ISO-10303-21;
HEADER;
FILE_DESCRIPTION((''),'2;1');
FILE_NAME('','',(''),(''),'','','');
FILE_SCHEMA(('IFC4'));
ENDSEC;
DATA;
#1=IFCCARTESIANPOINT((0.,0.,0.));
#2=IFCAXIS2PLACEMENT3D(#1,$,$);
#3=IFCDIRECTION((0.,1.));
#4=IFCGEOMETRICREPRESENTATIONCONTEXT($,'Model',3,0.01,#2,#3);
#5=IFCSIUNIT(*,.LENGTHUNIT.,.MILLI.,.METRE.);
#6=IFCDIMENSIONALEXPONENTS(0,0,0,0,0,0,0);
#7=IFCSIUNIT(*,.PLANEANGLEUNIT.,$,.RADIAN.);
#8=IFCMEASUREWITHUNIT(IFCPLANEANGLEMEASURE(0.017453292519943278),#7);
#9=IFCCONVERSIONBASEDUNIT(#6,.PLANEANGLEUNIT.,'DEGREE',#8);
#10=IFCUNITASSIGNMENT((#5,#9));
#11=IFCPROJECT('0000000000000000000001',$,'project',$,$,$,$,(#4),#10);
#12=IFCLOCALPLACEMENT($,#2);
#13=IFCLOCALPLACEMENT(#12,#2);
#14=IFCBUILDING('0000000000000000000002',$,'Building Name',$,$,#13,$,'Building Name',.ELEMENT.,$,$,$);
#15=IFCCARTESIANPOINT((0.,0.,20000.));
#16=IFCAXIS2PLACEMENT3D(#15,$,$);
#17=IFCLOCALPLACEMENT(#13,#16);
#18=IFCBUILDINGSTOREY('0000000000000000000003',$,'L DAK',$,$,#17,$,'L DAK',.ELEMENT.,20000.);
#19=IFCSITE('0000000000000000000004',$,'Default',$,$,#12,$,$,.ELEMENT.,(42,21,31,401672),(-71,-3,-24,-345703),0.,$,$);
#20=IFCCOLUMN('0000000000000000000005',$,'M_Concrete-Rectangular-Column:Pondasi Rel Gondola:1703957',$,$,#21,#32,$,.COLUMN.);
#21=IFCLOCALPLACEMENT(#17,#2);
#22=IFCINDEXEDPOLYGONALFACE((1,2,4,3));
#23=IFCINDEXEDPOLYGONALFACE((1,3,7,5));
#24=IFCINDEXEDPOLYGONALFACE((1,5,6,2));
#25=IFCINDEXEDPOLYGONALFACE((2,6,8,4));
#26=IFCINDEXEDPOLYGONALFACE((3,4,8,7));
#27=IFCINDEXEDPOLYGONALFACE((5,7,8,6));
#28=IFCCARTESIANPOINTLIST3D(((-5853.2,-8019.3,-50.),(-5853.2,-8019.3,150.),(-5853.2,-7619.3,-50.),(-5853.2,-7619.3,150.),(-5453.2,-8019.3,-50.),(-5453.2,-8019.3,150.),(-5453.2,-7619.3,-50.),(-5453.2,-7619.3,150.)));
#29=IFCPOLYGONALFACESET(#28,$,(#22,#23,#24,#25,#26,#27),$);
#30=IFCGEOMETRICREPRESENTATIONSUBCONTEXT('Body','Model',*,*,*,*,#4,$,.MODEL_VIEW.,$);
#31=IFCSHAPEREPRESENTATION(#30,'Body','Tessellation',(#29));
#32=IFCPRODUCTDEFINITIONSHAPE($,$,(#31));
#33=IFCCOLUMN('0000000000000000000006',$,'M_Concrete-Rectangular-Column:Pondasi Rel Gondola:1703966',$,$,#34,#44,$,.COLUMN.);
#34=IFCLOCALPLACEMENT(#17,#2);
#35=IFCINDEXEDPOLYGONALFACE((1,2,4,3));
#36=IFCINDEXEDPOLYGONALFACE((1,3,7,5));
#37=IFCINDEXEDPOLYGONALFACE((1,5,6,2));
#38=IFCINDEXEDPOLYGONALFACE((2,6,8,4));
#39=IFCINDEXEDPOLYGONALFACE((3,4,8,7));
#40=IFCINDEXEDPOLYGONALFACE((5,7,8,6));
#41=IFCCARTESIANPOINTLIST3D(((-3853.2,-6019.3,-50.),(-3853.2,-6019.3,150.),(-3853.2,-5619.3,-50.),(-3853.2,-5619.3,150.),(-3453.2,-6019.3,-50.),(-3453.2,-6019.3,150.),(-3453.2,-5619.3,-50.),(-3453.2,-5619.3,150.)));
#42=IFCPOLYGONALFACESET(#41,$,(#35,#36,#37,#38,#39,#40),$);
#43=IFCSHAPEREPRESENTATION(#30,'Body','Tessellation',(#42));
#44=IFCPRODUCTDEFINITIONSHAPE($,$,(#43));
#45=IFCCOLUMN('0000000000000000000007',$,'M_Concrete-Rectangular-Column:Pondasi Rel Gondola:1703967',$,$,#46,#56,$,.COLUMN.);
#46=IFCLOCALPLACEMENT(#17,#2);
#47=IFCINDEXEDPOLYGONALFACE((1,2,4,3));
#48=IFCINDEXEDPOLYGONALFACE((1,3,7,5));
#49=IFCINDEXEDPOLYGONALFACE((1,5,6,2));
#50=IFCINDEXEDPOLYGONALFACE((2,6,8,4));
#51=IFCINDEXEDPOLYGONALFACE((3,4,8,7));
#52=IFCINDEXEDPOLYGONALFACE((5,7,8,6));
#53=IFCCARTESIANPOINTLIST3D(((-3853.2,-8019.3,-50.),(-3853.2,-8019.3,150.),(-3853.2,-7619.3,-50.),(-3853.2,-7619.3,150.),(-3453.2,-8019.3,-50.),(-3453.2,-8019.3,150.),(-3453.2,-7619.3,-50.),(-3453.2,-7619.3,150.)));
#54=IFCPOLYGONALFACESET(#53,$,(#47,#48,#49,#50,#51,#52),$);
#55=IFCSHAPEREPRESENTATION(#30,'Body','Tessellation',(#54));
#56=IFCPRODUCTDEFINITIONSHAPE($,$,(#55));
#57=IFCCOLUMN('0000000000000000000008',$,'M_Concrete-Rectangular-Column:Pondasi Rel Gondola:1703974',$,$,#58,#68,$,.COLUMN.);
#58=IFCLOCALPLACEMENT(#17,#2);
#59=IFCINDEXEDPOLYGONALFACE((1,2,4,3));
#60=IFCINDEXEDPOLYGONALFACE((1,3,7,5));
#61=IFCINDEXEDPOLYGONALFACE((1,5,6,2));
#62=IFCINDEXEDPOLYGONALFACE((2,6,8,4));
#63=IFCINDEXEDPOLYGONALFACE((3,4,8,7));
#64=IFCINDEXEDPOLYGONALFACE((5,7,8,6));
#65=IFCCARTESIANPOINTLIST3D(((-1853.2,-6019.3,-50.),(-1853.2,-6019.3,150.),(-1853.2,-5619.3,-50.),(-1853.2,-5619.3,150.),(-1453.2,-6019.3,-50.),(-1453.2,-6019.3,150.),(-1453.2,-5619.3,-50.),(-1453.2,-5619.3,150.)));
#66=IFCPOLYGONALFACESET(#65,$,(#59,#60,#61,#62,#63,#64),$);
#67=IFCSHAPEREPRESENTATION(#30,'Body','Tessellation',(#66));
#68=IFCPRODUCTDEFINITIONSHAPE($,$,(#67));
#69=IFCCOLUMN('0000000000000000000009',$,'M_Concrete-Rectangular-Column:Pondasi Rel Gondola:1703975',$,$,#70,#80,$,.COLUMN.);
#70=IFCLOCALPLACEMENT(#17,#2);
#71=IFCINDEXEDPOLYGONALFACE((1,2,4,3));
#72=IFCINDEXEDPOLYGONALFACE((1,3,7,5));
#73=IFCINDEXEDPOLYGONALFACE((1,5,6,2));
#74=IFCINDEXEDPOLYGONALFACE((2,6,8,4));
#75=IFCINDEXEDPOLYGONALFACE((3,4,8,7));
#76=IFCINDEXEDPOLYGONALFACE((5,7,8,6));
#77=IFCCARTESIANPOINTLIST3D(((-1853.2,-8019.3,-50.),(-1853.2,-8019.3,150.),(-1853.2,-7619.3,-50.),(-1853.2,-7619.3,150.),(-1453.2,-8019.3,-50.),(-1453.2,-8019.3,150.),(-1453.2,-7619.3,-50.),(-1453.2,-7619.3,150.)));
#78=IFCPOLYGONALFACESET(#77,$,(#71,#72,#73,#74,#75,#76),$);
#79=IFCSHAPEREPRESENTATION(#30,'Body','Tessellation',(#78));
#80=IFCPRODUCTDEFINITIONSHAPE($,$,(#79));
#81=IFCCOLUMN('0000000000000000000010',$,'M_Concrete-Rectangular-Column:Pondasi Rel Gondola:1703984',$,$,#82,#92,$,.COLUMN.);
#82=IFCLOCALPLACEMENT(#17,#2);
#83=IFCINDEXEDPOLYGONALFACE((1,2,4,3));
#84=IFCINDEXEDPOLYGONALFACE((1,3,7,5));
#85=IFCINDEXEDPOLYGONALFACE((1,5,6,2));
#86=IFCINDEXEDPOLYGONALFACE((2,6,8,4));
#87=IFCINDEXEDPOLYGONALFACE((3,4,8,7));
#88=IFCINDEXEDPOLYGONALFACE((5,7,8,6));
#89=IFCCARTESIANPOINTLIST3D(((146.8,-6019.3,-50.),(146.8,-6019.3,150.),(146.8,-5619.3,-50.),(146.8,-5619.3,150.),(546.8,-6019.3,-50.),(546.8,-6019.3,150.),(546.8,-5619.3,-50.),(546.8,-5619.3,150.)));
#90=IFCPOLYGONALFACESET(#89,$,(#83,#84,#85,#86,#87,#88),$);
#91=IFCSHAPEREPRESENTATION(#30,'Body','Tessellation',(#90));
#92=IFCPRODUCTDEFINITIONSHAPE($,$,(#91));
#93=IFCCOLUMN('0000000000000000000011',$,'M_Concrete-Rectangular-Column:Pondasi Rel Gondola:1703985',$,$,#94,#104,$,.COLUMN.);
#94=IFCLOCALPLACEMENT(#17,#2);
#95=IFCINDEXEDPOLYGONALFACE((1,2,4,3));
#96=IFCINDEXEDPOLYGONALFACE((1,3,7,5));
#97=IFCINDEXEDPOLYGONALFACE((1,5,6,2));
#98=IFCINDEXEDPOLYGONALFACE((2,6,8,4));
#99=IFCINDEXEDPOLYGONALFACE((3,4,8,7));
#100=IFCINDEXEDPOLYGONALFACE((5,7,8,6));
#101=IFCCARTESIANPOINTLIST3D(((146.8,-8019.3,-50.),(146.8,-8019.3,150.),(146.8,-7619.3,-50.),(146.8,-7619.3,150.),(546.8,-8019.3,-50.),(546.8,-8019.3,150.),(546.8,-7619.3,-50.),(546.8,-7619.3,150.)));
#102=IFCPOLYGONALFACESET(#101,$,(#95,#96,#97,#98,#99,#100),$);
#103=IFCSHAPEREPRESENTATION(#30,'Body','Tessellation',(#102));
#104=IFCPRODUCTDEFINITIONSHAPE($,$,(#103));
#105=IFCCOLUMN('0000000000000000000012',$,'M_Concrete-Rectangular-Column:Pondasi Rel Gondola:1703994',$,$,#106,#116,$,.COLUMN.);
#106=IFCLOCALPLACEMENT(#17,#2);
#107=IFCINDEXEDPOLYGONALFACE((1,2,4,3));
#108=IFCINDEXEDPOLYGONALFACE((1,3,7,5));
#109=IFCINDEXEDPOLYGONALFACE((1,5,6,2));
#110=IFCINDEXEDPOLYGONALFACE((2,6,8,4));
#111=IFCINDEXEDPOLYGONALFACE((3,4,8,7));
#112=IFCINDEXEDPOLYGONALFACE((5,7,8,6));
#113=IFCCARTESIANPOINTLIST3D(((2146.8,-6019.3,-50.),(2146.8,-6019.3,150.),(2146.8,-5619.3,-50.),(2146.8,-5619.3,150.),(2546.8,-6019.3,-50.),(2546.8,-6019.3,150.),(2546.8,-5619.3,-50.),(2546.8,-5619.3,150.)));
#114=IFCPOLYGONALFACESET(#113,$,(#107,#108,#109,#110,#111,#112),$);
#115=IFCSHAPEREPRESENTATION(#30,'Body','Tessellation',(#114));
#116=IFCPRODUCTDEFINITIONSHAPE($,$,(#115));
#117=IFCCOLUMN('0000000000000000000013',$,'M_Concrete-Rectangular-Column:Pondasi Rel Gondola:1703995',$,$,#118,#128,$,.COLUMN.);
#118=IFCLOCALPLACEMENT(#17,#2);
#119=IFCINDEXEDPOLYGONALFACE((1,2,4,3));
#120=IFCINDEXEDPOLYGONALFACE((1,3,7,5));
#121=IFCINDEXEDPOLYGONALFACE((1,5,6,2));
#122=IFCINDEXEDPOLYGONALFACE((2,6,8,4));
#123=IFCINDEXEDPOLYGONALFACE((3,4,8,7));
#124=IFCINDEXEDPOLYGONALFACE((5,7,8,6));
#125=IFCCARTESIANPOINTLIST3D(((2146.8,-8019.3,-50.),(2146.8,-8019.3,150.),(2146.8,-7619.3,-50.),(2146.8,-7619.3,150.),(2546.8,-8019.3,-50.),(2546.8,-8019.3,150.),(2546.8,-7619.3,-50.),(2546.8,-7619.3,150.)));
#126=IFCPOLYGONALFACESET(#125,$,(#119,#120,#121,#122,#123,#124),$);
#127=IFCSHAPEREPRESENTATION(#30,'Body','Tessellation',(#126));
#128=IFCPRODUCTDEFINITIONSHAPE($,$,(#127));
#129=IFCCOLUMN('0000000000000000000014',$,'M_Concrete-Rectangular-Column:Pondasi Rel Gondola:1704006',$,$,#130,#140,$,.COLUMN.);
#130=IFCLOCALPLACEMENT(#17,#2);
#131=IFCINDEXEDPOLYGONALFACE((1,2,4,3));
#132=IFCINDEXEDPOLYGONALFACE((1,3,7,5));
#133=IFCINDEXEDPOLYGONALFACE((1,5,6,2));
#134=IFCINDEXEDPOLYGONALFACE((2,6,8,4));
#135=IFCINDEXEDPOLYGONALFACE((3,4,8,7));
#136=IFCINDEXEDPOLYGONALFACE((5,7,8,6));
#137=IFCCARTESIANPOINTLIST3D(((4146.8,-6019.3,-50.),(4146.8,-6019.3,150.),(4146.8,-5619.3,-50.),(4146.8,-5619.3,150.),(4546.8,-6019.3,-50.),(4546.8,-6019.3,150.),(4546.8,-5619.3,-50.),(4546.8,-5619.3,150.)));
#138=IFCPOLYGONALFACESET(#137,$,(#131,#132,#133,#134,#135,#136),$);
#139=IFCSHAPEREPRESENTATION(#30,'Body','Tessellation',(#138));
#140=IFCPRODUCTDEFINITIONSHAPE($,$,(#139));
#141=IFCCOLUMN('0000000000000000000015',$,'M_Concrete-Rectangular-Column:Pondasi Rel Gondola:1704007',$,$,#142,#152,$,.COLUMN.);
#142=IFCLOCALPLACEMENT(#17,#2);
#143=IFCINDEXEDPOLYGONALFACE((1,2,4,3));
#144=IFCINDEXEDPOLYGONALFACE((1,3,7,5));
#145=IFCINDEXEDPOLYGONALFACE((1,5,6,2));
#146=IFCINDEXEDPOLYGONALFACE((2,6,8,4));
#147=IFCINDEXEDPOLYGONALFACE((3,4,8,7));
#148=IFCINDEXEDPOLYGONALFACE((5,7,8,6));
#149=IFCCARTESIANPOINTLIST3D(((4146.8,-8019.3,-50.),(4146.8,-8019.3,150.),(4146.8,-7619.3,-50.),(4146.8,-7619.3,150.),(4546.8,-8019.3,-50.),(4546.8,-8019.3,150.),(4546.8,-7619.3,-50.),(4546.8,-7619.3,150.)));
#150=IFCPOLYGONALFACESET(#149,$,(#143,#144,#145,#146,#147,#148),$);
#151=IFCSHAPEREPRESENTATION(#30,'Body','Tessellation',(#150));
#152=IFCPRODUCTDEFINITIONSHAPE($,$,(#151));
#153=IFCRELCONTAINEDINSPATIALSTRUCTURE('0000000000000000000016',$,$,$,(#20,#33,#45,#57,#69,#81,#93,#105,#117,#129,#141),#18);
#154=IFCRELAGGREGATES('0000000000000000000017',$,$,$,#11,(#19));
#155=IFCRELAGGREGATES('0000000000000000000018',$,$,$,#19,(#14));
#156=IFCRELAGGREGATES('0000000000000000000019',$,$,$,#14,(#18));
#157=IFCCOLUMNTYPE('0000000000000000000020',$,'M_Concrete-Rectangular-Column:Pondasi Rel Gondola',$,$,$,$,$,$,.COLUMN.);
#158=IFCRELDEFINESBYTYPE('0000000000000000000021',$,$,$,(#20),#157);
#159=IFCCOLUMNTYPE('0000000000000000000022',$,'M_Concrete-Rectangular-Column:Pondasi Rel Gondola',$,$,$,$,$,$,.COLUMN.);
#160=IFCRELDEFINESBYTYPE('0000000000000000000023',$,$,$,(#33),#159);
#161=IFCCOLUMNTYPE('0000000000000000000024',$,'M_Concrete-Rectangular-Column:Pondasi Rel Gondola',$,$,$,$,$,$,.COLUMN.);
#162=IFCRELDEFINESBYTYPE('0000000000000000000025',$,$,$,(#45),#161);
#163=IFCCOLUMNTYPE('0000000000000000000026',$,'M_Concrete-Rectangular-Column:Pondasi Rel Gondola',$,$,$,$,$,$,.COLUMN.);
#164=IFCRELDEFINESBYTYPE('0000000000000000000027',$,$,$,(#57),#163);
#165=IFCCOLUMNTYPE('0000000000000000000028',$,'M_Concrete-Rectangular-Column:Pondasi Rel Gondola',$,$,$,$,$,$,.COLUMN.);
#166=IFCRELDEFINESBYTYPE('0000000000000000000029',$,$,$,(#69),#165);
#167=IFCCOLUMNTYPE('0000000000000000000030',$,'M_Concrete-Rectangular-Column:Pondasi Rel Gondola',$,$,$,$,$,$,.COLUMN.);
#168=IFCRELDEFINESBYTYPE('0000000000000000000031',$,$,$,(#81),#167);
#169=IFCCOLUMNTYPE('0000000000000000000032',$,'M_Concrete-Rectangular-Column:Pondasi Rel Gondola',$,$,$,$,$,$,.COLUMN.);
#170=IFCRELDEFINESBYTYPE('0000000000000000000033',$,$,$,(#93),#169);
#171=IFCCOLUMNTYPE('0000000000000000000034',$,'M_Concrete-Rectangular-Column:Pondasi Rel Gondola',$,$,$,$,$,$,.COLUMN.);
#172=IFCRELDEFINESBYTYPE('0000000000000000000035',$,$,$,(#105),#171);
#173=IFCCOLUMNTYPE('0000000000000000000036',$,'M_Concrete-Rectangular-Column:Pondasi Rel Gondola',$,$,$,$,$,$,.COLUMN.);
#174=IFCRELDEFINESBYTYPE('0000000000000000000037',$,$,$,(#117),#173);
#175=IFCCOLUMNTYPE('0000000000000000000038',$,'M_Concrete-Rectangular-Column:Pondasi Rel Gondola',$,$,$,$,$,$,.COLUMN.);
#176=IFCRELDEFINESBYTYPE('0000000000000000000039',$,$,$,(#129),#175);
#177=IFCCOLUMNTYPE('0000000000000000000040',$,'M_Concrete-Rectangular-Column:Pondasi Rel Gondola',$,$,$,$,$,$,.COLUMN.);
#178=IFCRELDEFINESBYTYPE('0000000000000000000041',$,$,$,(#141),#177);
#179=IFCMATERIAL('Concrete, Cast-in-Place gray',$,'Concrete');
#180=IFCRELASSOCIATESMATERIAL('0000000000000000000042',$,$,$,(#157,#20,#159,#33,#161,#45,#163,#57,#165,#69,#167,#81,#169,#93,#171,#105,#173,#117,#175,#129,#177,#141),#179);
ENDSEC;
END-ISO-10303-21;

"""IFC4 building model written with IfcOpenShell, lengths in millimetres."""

from ifc_helpers import new_model, entity, si_unit, converted_unit, direction, frame, origin, place, context, subcontext, project, spatial, indexed_curve, outline, extrude, source, transform, mapped, material, type_object, type_shapes, element, save


model = new_model("IFC4")

# Units and contexts
model_context = context("Model", 3, precision=0.01, world=origin(), true_north=direction((0.0, 1.0)))
body_context = subcontext(model_context, "Body", "Model", "MODEL_VIEW")
ifc_project = project(units=[si_unit("LENGTHUNIT", "METRE", prefix="MILLI"), converted_unit("PLANEANGLEUNIT", "DEGREE", entity("IfcPlaneAngleMeasure", 0.017453292519943278), si_unit("PLANEANGLEUNIT", "RADIAN"), dimensions=[0, 0, 0, 0, 0, 0, 0])], contexts=[model_context])

# Site, building, storey
site_placement = place(None, origin())
site = spatial("IfcSite", under=ifc_project, at=site_placement, Name="Default", CompositionType="ELEMENT", RefLatitude=(42, 21, 31, 401672), RefLongitude=(-71, -3, -24, -345703), RefElevation=0.0)
building_placement = place(site_placement, origin())
building = spatial("IfcBuilding", under=site, at=building_placement, Name="Building Name", LongName="Building Name", CompositionType="ELEMENT")
storey_placement = place(building_placement, frame((0.0, 0.0, 20000.0)))
storey = spatial("IfcBuildingStorey", under=building, at=storey_placement, Name="L DAK", LongName="L DAK", CompositionType="ELEMENT", Elevation=20000.0)

# Columns
ifc_material = material(Name="Concrete, Cast-in-Place gray", Category="Concrete")
column_type_1 = type_object("IfcColumnType", Name="M_Concrete-Rectangular-Column:Pondasi Rel Gondola", PredefinedType="COLUMN", material=ifc_material)
shared_shape_1 = source(origin(), body_context, "Body", "SweptSolid", [
    extrude(outline(indexed_curve([(-200.0, -200.0), (200.0, -200.0), (200.0, 200.0), (-200.0, 200.0), (-200.0, -200.0)], self_intersect=False)), frame((-5653.2, -7819.3, 19950.0), z_axis=(0.0, 0.0, 1.0), x_axis=(-1.0, 0.0, 0.0)), (0.0, 0.0, 1.0), 200.0),
])
type_shapes(column_type_1, [shared_shape_1])
column_1_placement = place(storey_placement, frame((0.0, 0.0, -20000.0)))
element("IfcColumn", 1, at=column_1_placement, inside=storey, type_object=column_type_1, material=ifc_material, Name="M_Concrete-Rectangular-Column:Pondasi Rel Gondola:1703957", PredefinedType="COLUMN", context=body_context, shape_type="MappedRepresentation", body=[
    mapped(shared_shape_1, transform((0.0, 0.0, 0.0), scale=1.0)),
])
column_type_2 = type_object("IfcColumnType", Name="M_Concrete-Rectangular-Column:Pondasi Rel Gondola", PredefinedType="COLUMN", material=ifc_material)
shared_shape_2 = source(origin(), body_context, "Body", "SweptSolid", [
    extrude(outline(indexed_curve([(-200.0, -200.0), (200.0, -200.0), (200.0, 200.0), (-200.0, 200.0), (-200.0, -200.0)], self_intersect=False)), frame((-3653.2, -5819.3, 19950.0), z_axis=(0.0, 0.0, 1.0), x_axis=(-1.0, 0.0, 0.0)), (0.0, 0.0, 1.0), 200.0),
])
type_shapes(column_type_2, [shared_shape_2])
column_2_placement = place(storey_placement, frame((0.0, 0.0, -20000.0)))
element("IfcColumn", 2, at=column_2_placement, inside=storey, type_object=column_type_2, material=ifc_material, Name="M_Concrete-Rectangular-Column:Pondasi Rel Gondola:1703966", PredefinedType="COLUMN", context=body_context, shape_type="MappedRepresentation", body=[
    mapped(shared_shape_2, transform((0.0, 0.0, 0.0), scale=1.0)),
])
column_type_3 = type_object("IfcColumnType", Name="M_Concrete-Rectangular-Column:Pondasi Rel Gondola", PredefinedType="COLUMN", material=ifc_material)
shared_shape_3 = source(origin(), body_context, "Body", "SweptSolid", [
    extrude(outline(indexed_curve([(-200.0, -200.0), (200.0, -200.0), (200.0, 200.0), (-200.0, 200.0), (-200.0, -200.0)], self_intersect=False)), frame((-3653.2, -7819.3, 19950.0), z_axis=(0.0, 0.0, 1.0), x_axis=(-1.0, 0.0, 0.0)), (0.0, 0.0, 1.0), 200.0),
])
type_shapes(column_type_3, [shared_shape_3])
column_3_placement = place(storey_placement, frame((0.0, 0.0, -20000.0)))
element("IfcColumn", 3, at=column_3_placement, inside=storey, type_object=column_type_3, material=ifc_material, Name="M_Concrete-Rectangular-Column:Pondasi Rel Gondola:1703967", PredefinedType="COLUMN", context=body_context, shape_type="MappedRepresentation", body=[
    mapped(shared_shape_3, transform((0.0, 0.0, 0.0), scale=1.0)),
])
column_type_4 = type_object("IfcColumnType", Name="M_Concrete-Rectangular-Column:Pondasi Rel Gondola", PredefinedType="COLUMN", material=ifc_material)
shared_shape_4 = source(origin(), body_context, "Body", "SweptSolid", [
    extrude(outline(indexed_curve([(-200.0, -200.0), (200.0, -200.0), (200.0, 200.0), (-200.0, 200.0), (-200.0, -200.0)], self_intersect=False)), frame((-1653.2, -5819.3, 19950.0), z_axis=(0.0, 0.0, 1.0), x_axis=(-1.0, 0.0, 0.0)), (0.0, 0.0, 1.0), 200.0),
])
type_shapes(column_type_4, [shared_shape_4])
column_4_placement = place(storey_placement, frame((0.0, 0.0, -20000.0)))
element("IfcColumn", 4, at=column_4_placement, inside=storey, type_object=column_type_4, material=ifc_material, Name="M_Concrete-Rectangular-Column:Pondasi Rel Gondola:1703974", PredefinedType="COLUMN", context=body_context, shape_type="MappedRepresentation", body=[
    mapped(shared_shape_4, transform((0.0, 0.0, 0.0), scale=1.0)),
])
column_type_5 = type_object("IfcColumnType", Name="M_Concrete-Rectangular-Column:Pondasi Rel Gondola", PredefinedType="COLUMN", material=ifc_material)
shared_shape_5 = source(origin(), body_context, "Body", "SweptSolid", [
    extrude(outline(indexed_curve([(-200.0, -200.0), (200.0, -200.0), (200.0, 200.0), (-200.0, 200.0), (-200.0, -200.0)], self_intersect=False)), frame((-1653.2, -7819.3, 19950.0), z_axis=(0.0, 0.0, 1.0), x_axis=(-1.0, 0.0, 0.0)), (0.0, 0.0, 1.0), 200.0),
])
type_shapes(column_type_5, [shared_shape_5])
column_5_placement = place(storey_placement, frame((0.0, 0.0, -20000.0)))
element("IfcColumn", 5, at=column_5_placement, inside=storey, type_object=column_type_5, material=ifc_material, Name="M_Concrete-Rectangular-Column:Pondasi Rel Gondola:1703975", PredefinedType="COLUMN", context=body_context, shape_type="MappedRepresentation", body=[
    mapped(shared_shape_5, transform((0.0, 0.0, 0.0), scale=1.0)),
])
column_type_6 = type_object("IfcColumnType", Name="M_Concrete-Rectangular-Column:Pondasi Rel Gondola", PredefinedType="COLUMN", material=ifc_material)
shared_shape_6 = source(origin(), body_context, "Body", "SweptSolid", [
    extrude(outline(indexed_curve([(-200.0, -200.0), (200.0, -200.0), (200.0, 200.0), (-200.0, 200.0), (-200.0, -200.0)], self_intersect=False)), frame((346.8, -5819.3, 19950.0), z_axis=(0.0, 0.0, 1.0), x_axis=(-1.0, 0.0, 0.0)), (0.0, 0.0, 1.0), 200.0),
])
type_shapes(column_type_6, [shared_shape_6])
column_6_placement = place(storey_placement, frame((0.0, 0.0, -20000.0)))
element("IfcColumn", 6, at=column_6_placement, inside=storey, type_object=column_type_6, material=ifc_material, Name="M_Concrete-Rectangular-Column:Pondasi Rel Gondola:1703984", PredefinedType="COLUMN", context=body_context, shape_type="MappedRepresentation", body=[
    mapped(shared_shape_6, transform((0.0, 0.0, 0.0), scale=1.0)),
])
column_type_7 = type_object("IfcColumnType", Name="M_Concrete-Rectangular-Column:Pondasi Rel Gondola", PredefinedType="COLUMN", material=ifc_material)
shared_shape_7 = source(origin(), body_context, "Body", "SweptSolid", [
    extrude(outline(indexed_curve([(-200.0, -200.0), (200.0, -200.0), (200.0, 200.0), (-200.0, 200.0), (-200.0, -200.0)], self_intersect=False)), frame((346.8, -7819.3, 19950.0), z_axis=(0.0, 0.0, 1.0), x_axis=(-1.0, 0.0, 0.0)), (0.0, 0.0, 1.0), 200.0),
])
type_shapes(column_type_7, [shared_shape_7])
column_7_placement = place(storey_placement, frame((0.0, 0.0, -20000.0)))
element("IfcColumn", 7, at=column_7_placement, inside=storey, type_object=column_type_7, material=ifc_material, Name="M_Concrete-Rectangular-Column:Pondasi Rel Gondola:1703985", PredefinedType="COLUMN", context=body_context, shape_type="MappedRepresentation", body=[
    mapped(shared_shape_7, transform((0.0, 0.0, 0.0), scale=1.0)),
])
column_type_8 = type_object("IfcColumnType", Name="M_Concrete-Rectangular-Column:Pondasi Rel Gondola", PredefinedType="COLUMN", material=ifc_material)
shared_shape_8 = source(origin(), body_context, "Body", "SweptSolid", [
    extrude(outline(indexed_curve([(-200.0, -200.0), (200.0, -200.0), (200.0, 200.0), (-200.0, 200.0), (-200.0, -200.0)], self_intersect=False)), frame((2346.8, -5819.3, 19950.0), z_axis=(0.0, 0.0, 1.0), x_axis=(-1.0, 0.0, 0.0)), (0.0, 0.0, 1.0), 200.0),
])
type_shapes(column_type_8, [shared_shape_8])
column_8_placement = place(storey_placement, frame((0.0, 0.0, -20000.0)))
element("IfcColumn", 8, at=column_8_placement, inside=storey, type_object=column_type_8, material=ifc_material, Name="M_Concrete-Rectangular-Column:Pondasi Rel Gondola:1703994", PredefinedType="COLUMN", context=body_context, shape_type="MappedRepresentation", body=[
    mapped(shared_shape_8, transform((0.0, 0.0, 0.0), scale=1.0)),
])
column_type_9 = type_object("IfcColumnType", Name="M_Concrete-Rectangular-Column:Pondasi Rel Gondola", PredefinedType="COLUMN", material=ifc_material)
shared_shape_9 = source(origin(), body_context, "Body", "SweptSolid", [
    extrude(outline(indexed_curve([(-200.0, -200.0), (200.0, -200.0), (200.0, 200.0), (-200.0, 200.0), (-200.0, -200.0)], self_intersect=False)), frame((2346.8, -7819.3, 19950.0), z_axis=(0.0, 0.0, 1.0), x_axis=(-1.0, 0.0, 0.0)), (0.0, 0.0, 1.0), 200.0),
])
type_shapes(column_type_9, [shared_shape_9])
column_9_placement = place(storey_placement, frame((0.0, 0.0, -20000.0)))
element("IfcColumn", 9, at=column_9_placement, inside=storey, type_object=column_type_9, material=ifc_material, Name="M_Concrete-Rectangular-Column:Pondasi Rel Gondola:1703995", PredefinedType="COLUMN", context=body_context, shape_type="MappedRepresentation", body=[
    mapped(shared_shape_9, transform((0.0, 0.0, 0.0), scale=1.0)),
])
column_type_10 = type_object("IfcColumnType", Name="M_Concrete-Rectangular-Column:Pondasi Rel Gondola", PredefinedType="COLUMN", material=ifc_material)
shared_shape_10 = source(origin(), body_context, "Body", "SweptSolid", [
    extrude(outline(indexed_curve([(-200.0, -200.0), (200.0, -200.0), (200.0, 200.0), (-200.0, 200.0), (-200.0, -200.0)], self_intersect=False)), frame((4346.8, -5819.3, 19950.0), z_axis=(0.0, 0.0, 1.0), x_axis=(-1.0, 0.0, 0.0)), (0.0, 0.0, 1.0), 200.0),
])
type_shapes(column_type_10, [shared_shape_10])
column_10_placement = place(storey_placement, frame((0.0, 0.0, -20000.0)))
element("IfcColumn", 10, at=column_10_placement, inside=storey, type_object=column_type_10, material=ifc_material, Name="M_Concrete-Rectangular-Column:Pondasi Rel Gondola:1704006", PredefinedType="COLUMN", context=body_context, shape_type="MappedRepresentation", body=[
    mapped(shared_shape_10, transform((0.0, 0.0, 0.0), scale=1.0)),
])
column_type_11 = type_object("IfcColumnType", Name="M_Concrete-Rectangular-Column:Pondasi Rel Gondola", PredefinedType="COLUMN", material=ifc_material)
shared_shape_11 = source(origin(), body_context, "Body", "SweptSolid", [
    extrude(outline(indexed_curve([(-200.0, -200.0), (200.0, -200.0), (200.0, 200.0), (-200.0, 200.0), (-200.0, -200.0)], self_intersect=False)), frame((4346.8, -7819.3, 19950.0), z_axis=(0.0, 0.0, 1.0), x_axis=(-1.0, 0.0, 0.0)), (0.0, 0.0, 1.0), 200.0),
])
type_shapes(column_type_11, [shared_shape_11])
column_11_placement = place(storey_placement, frame((0.0, 0.0, -20000.0)))
element("IfcColumn", 11, at=column_11_placement, inside=storey, type_object=column_type_11, material=ifc_material, Name="M_Concrete-Rectangular-Column:Pondasi Rel Gondola:1704007", PredefinedType="COLUMN", context=body_context, shape_type="MappedRepresentation", body=[
    mapped(shared_shape_11, transform((0.0, 0.0, 0.0), scale=1.0)),
])

save(model, "model.ifc")
